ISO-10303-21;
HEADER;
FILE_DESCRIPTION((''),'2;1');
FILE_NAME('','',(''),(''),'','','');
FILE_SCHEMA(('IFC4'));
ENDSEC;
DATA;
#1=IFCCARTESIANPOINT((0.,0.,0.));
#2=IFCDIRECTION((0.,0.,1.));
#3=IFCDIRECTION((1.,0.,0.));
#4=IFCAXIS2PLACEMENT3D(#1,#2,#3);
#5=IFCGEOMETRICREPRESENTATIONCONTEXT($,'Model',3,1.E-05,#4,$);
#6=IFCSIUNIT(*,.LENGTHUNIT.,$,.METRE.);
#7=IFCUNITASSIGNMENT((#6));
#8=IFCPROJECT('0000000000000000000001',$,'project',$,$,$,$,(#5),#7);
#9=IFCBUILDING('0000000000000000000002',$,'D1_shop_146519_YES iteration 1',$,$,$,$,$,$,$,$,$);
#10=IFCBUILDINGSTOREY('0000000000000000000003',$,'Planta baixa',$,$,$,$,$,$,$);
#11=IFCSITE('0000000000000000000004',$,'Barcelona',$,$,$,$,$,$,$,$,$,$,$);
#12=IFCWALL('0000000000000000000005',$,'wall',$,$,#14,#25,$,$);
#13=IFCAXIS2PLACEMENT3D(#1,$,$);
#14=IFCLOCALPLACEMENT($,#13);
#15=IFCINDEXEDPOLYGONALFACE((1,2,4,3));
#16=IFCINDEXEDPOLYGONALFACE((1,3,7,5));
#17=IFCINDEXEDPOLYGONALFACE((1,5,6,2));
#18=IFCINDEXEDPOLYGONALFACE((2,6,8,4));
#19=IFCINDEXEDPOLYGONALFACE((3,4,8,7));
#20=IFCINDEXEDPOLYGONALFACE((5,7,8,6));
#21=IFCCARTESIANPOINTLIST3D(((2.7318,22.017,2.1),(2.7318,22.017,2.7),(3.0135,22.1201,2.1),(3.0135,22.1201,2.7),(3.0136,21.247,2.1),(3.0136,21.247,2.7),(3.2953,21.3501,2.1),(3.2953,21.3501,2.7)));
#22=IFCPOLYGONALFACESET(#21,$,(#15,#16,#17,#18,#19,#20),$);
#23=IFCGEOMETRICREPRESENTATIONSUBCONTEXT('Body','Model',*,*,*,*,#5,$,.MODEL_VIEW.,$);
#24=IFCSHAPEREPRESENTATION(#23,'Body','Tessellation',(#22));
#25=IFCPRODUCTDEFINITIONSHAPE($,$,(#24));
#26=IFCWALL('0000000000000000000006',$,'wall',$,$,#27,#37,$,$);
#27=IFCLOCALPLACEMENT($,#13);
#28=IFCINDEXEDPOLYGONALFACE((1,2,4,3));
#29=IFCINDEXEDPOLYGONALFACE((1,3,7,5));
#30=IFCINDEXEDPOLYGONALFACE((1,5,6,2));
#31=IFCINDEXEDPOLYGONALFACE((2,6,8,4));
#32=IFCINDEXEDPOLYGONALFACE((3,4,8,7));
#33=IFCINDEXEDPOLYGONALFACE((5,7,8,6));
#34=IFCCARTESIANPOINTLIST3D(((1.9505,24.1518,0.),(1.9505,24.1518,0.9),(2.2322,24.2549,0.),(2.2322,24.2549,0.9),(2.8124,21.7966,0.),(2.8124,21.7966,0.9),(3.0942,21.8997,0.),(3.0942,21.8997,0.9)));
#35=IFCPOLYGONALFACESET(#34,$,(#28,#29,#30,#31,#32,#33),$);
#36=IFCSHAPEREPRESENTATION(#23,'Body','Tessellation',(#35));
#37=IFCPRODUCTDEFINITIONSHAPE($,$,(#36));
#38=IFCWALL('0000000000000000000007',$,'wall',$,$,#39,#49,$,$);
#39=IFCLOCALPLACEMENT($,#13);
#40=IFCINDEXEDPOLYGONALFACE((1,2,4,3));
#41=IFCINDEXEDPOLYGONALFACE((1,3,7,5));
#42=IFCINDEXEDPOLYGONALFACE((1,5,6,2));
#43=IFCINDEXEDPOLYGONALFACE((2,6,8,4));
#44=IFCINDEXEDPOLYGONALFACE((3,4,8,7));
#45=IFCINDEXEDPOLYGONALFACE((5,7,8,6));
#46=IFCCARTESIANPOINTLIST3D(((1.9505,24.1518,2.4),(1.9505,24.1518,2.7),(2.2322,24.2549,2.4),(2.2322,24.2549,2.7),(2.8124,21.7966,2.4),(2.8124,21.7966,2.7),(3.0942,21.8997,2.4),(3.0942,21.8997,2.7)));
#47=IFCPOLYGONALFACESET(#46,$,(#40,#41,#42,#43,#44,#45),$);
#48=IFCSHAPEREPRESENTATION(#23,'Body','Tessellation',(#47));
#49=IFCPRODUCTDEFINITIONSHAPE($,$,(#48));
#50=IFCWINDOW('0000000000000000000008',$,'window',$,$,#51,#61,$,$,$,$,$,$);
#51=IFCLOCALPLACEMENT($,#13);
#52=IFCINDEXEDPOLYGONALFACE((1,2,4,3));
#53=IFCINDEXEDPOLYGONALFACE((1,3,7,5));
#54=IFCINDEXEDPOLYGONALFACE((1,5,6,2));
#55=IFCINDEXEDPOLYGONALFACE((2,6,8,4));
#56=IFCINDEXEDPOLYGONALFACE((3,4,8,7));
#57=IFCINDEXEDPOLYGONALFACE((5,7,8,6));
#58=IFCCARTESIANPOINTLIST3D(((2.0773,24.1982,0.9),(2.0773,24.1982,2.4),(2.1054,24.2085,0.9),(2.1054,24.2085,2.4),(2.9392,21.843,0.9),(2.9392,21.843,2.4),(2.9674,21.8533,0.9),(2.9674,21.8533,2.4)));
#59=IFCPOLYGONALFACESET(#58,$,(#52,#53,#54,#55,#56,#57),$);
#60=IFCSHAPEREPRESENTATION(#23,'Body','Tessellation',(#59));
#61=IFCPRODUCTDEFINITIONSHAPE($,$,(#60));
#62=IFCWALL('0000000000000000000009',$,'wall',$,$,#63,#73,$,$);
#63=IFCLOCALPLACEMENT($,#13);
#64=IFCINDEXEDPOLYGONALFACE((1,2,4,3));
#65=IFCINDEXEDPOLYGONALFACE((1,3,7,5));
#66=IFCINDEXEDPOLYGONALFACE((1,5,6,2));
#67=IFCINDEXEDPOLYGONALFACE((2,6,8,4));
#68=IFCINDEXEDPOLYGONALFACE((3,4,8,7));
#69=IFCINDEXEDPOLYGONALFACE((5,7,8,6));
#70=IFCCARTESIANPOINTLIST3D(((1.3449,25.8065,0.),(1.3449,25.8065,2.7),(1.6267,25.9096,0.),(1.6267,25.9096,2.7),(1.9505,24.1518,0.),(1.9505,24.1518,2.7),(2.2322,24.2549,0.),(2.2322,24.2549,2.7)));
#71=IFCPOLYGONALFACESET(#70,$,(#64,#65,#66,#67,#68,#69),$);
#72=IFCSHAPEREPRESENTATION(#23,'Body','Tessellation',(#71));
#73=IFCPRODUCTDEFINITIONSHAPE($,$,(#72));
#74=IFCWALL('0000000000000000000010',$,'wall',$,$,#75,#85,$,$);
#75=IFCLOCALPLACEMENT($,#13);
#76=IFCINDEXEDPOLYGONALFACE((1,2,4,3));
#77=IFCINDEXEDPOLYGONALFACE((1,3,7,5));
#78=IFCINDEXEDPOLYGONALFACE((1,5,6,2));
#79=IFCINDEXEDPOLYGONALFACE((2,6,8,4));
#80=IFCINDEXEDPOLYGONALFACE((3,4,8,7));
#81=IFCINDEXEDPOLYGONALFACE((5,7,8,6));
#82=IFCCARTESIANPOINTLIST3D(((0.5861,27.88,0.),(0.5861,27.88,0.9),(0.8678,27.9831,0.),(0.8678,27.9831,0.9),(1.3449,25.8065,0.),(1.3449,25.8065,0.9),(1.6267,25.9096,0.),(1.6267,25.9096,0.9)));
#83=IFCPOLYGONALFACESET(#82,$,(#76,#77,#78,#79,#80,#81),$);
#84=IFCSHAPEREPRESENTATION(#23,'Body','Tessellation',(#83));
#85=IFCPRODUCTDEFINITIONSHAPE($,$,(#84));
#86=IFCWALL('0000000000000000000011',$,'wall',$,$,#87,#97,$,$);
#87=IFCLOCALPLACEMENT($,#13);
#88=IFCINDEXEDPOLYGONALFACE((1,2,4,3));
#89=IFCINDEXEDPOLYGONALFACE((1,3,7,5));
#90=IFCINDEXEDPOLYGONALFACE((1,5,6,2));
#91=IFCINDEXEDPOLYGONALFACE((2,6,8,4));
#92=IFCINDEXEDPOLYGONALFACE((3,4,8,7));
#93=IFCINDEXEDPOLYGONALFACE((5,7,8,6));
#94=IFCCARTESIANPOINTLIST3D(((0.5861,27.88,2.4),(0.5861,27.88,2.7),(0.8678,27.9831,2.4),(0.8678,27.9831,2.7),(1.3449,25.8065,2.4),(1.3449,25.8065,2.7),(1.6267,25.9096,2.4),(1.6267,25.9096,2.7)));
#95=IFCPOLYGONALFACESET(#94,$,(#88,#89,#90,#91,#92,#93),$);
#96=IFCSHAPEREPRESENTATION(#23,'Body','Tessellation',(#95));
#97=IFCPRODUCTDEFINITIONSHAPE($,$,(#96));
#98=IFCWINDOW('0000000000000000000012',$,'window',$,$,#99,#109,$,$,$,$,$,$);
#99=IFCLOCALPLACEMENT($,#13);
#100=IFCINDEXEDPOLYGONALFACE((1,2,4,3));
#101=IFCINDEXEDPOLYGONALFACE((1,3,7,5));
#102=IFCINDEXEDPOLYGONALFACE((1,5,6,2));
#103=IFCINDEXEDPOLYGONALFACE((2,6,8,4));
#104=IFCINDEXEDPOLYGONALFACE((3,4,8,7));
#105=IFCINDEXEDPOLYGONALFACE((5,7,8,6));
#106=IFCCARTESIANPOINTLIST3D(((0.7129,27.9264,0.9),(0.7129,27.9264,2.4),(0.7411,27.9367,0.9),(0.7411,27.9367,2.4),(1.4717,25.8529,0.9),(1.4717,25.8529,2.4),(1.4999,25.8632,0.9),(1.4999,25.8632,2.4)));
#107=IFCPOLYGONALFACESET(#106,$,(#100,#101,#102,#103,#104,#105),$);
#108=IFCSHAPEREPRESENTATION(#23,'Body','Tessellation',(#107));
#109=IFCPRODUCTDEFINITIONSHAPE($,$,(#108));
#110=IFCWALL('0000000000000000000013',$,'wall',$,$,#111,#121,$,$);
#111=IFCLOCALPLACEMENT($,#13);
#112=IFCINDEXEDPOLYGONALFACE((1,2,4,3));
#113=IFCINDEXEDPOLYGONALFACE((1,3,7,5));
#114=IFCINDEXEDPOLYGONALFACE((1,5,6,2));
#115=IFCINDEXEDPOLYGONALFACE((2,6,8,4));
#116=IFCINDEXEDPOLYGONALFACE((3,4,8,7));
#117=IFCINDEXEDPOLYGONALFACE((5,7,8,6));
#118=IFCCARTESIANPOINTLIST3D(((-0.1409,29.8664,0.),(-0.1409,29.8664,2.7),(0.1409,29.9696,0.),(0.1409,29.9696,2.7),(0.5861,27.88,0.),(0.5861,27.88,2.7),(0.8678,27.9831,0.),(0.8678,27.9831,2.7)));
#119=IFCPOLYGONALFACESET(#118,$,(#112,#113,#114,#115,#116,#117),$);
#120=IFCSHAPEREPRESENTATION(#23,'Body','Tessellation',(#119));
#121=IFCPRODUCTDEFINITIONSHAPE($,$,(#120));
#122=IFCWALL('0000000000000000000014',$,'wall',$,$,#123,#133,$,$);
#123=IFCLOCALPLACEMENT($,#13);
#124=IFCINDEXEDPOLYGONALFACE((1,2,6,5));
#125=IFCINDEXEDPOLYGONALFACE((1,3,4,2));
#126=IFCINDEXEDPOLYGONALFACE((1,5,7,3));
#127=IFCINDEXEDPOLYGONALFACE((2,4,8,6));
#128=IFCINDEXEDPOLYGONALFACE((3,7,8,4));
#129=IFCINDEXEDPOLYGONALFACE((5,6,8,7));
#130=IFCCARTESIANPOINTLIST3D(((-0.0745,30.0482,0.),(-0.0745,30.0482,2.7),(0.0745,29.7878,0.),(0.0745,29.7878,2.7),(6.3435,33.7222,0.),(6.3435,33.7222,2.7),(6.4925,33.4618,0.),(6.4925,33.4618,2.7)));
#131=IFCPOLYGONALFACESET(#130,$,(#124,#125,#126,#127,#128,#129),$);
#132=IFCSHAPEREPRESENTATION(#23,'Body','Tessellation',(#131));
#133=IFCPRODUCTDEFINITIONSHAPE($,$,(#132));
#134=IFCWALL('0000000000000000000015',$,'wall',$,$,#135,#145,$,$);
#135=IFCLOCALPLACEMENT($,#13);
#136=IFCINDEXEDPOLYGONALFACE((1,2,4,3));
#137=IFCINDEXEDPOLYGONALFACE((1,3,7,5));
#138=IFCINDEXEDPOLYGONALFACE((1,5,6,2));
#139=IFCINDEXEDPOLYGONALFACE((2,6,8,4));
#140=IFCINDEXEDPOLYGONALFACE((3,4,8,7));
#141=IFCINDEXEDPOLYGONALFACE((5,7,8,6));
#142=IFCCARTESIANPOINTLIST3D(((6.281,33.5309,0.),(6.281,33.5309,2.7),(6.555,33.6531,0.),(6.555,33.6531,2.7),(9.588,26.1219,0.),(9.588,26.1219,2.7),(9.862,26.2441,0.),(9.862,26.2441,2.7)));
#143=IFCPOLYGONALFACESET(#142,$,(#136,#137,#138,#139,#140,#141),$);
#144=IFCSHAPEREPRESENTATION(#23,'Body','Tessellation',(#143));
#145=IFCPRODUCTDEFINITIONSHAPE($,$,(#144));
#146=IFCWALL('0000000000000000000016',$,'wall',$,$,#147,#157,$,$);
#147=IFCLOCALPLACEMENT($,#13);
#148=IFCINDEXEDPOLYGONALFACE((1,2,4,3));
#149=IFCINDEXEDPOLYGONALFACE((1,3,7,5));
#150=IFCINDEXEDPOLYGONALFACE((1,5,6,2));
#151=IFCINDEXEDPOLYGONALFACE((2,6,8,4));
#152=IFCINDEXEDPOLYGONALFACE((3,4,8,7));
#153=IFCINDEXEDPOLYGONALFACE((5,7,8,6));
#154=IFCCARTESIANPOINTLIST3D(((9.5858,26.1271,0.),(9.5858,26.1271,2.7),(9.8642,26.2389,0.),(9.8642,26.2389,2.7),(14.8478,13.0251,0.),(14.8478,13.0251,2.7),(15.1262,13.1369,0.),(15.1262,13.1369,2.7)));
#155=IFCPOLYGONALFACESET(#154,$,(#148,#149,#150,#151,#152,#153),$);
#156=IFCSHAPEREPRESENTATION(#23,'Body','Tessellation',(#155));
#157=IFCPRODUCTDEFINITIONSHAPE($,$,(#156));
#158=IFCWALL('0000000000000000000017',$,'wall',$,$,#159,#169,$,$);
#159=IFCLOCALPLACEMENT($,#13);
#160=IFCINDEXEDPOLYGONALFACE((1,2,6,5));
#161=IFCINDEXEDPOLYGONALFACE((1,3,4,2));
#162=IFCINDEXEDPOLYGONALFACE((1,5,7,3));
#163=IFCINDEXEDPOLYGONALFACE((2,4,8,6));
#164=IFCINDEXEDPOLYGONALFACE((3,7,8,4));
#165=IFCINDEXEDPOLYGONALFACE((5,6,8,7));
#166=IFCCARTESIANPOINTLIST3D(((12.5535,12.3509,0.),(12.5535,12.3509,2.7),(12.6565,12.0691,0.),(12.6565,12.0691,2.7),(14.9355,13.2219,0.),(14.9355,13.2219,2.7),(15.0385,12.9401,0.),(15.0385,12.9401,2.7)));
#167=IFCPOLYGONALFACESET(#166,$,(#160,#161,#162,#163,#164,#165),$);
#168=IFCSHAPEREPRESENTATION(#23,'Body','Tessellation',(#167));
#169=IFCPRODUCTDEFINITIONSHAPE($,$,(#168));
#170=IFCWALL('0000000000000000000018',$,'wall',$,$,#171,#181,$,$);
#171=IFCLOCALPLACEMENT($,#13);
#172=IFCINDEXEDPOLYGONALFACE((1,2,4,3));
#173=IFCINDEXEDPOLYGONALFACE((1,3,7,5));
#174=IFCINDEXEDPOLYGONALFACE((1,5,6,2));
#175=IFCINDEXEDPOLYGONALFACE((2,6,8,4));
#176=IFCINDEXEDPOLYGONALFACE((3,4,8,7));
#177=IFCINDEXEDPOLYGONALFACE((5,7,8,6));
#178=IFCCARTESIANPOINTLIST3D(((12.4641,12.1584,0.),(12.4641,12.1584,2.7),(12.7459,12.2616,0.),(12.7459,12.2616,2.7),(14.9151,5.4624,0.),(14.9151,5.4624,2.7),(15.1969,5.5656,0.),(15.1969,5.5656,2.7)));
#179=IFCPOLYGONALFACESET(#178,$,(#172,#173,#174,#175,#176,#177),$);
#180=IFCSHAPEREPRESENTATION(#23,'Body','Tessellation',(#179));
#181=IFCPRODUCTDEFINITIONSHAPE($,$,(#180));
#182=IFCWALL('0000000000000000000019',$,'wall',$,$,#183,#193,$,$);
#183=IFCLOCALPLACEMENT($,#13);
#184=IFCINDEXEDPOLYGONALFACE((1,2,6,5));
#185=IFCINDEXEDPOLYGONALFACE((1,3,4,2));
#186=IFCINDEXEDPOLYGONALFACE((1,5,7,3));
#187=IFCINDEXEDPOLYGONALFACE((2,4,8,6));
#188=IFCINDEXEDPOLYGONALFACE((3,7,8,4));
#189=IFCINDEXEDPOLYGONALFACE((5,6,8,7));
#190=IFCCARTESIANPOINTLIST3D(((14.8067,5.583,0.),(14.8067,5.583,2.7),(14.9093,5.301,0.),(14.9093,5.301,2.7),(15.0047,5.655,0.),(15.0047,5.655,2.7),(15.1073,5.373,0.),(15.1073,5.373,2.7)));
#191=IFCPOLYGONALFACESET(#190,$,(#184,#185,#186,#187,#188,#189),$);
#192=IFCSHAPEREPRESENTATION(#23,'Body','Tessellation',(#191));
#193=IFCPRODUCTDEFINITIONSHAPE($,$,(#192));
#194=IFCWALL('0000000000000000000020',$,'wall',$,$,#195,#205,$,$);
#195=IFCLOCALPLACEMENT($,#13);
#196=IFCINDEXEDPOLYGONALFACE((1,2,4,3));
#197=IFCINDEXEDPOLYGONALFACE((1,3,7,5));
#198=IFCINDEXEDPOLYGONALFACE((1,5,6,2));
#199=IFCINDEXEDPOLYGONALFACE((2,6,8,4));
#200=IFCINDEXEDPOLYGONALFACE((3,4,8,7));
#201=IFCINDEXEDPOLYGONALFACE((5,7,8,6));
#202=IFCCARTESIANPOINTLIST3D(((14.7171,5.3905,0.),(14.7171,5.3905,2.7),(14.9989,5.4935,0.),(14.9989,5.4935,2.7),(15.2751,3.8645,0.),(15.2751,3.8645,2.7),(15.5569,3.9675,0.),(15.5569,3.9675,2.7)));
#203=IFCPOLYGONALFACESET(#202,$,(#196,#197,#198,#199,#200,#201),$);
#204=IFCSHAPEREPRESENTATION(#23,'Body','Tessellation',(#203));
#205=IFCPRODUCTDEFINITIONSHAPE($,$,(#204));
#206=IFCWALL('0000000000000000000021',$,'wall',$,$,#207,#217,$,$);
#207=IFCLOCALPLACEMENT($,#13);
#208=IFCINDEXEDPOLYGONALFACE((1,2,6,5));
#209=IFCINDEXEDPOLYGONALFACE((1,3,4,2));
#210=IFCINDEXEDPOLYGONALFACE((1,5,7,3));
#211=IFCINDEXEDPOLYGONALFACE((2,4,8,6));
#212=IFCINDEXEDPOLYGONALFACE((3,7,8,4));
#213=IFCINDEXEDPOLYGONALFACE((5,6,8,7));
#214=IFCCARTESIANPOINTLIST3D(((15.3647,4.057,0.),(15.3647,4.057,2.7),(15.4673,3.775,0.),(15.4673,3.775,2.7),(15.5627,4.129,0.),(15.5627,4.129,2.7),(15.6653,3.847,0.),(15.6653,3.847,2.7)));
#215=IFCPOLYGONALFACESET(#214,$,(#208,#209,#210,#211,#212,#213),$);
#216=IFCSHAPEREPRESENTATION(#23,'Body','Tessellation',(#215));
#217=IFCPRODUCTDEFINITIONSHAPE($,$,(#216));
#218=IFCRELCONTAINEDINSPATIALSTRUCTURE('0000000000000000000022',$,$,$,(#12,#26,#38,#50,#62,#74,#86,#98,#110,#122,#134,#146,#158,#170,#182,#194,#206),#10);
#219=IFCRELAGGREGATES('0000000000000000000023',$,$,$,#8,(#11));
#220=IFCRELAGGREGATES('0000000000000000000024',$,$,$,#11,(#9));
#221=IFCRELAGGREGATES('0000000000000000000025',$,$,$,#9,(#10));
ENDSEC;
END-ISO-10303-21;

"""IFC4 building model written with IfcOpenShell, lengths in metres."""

from ifc_helpers import new_model, si_unit, frame, origin, origin_with_axes, place, context, subcontext, project, spatial, polyline, outline, extrude, element, save


model = new_model("IFC4")

# Units and contexts
model_context = context("Model", 3, precision=1e-05, world=origin_with_axes())
body_context = subcontext(model_context, "Body", "Model", "MODEL_VIEW")
ifc_project = project(units=[si_unit("LENGTHUNIT", "METRE")], contexts=[model_context])

# Site, building, storey
site = spatial("IfcSite", under=ifc_project, Name="Barcelona")
building = spatial("IfcBuilding", under=site, Name="D1_shop_146519_YES iteration 1")
storey = spatial("IfcBuildingStorey", under=building, Name="Planta baixa")

# Walls
wall_1_placement = place(None, origin_with_axes())
element("IfcWall", 1, at=wall_1_placement, inside=storey, Name="wall", context=body_context, shape_type="SweptSolid", body=[
    extrude(outline(polyline([(3.0136, 21.247), (2.7318, 22.017), (3.0135, 22.1201), (3.2953, 21.3501), (3.0136, 21.247)])), frame((0.0, 0.0, 2.1)), (0.0, 0.0, 1.0), 0.6),
])
wall_2_placement = place(None, origin_with_axes())
element("IfcWall", 2, at=wall_2_placement, inside=storey, Name="wall", context=body_context, shape_type="SweptSolid", body=[
    extrude(outline(polyline([(2.8124, 21.7966), (1.9505, 24.1518), (2.2322, 24.2549), (3.0942, 21.8997), (2.8124, 21.7966)])), origin(), (0.0, 0.0, 1.0), 0.9),
])
wall_3_placement = place(None, origin_with_axes())
element("IfcWall", 3, at=wall_3_placement, inside=storey, Name="wall", context=body_context, shape_type="SweptSolid", body=[
    extrude(outline(polyline([(2.8124, 21.7966), (1.9505, 24.1518), (2.2322, 24.2549), (3.0942, 21.8997), (2.8124, 21.7966)])), frame((0.0, 0.0, 2.4)), (0.0, 0.0, 1.0), 0.3),
])

# Window
window_1_placement = place(None, origin_with_axes())
element("IfcWindow", 4, at=window_1_placement, inside=storey, Name="window", context=body_context, shape_type="SweptSolid", body=[
    extrude(outline(polyline([(2.9392, 21.843), (2.0773, 24.1982), (2.1054, 24.2085), (2.9674, 21.8533), (2.9392, 21.843)])), frame((0.0, 0.0, 0.9)), (0.0, 0.0, 1.0), 1.5),
])

# Walls
wall_4_placement = place(None, origin_with_axes())
element("IfcWall", 5, at=wall_4_placement, inside=storey, Name="wall", context=body_context, shape_type="SweptSolid", body=[
    extrude(outline(polyline([(1.9505, 24.1518), (1.3449, 25.8065), (1.6267, 25.9096), (2.2322, 24.2549), (1.9505, 24.1518)])), origin(), (0.0, 0.0, 1.0), 2.7),
])
wall_5_placement = place(None, origin_with_axes())
element("IfcWall", 6, at=wall_5_placement, inside=storey, Name="wall", context=body_context, shape_type="SweptSolid", body=[
    extrude(outline(polyline([(1.3449, 25.8065), (0.5861, 27.88), (0.8678, 27.9831), (1.6267, 25.9096), (1.3449, 25.8065)])), origin(), (0.0, 0.0, 1.0), 0.9),
])
wall_6_placement = place(None, origin_with_axes())
element("IfcWall", 7, at=wall_6_placement, inside=storey, Name="wall", context=body_context, shape_type="SweptSolid", body=[
    extrude(outline(polyline([(1.3449, 25.8065), (0.5861, 27.88), (0.8678, 27.9831), (1.6267, 25.9096), (1.3449, 25.8065)])), frame((0.0, 0.0, 2.4)), (0.0, 0.0, 1.0), 0.3),
])

# Window
window_2_placement = place(None, origin_with_axes())
element("IfcWindow", 8, at=window_2_placement, inside=storey, Name="window", context=body_context, shape_type="SweptSolid", body=[
    extrude(outline(polyline([(1.4717, 25.8529), (0.7129, 27.9264), (0.7411, 27.9367), (1.4999, 25.8632), (1.4717, 25.8529)])), frame((0.0, 0.0, 0.9)), (0.0, 0.0, 1.0), 1.5),
])

# Walls
wall_7_placement = place(None, origin_with_axes())
element("IfcWall", 9, at=wall_7_placement, inside=storey, Name="wall", context=body_context, shape_type="SweptSolid", body=[
    extrude(outline(polyline([(0.5861, 27.88), (-0.1409, 29.8664), (0.1409, 29.9696), (0.8678, 27.9831), (0.5861, 27.88)])), origin(), (0.0, 0.0, 1.0), 2.7),
])
wall_8_placement = place(None, origin_with_axes())
element("IfcWall", 10, at=wall_8_placement, inside=storey, Name="wall", context=body_context, shape_type="SweptSolid", body=[
    extrude(outline(polyline([(-0.0745, 30.0482), (6.3435, 33.7222), (6.4925, 33.4618), (0.0745, 29.7878), (-0.0745, 30.0482)])), origin(), (0.0, 0.0, 1.0), 2.7),
])
wall_9_placement = place(None, origin_with_axes())
element("IfcWall", 11, at=wall_9_placement, inside=storey, Name="wall", context=body_context, shape_type="SweptSolid", body=[
    extrude(outline(polyline([(6.555, 33.6531), (9.862, 26.2441), (9.588, 26.1219), (6.281, 33.5309), (6.555, 33.6531)])), origin(), (0.0, 0.0, 1.0), 2.7),
])
wall_10_placement = place(None, origin_with_axes())
element("IfcWall", 12, at=wall_10_placement, inside=storey, Name="wall", context=body_context, shape_type="SweptSolid", body=[
    extrude(outline(polyline([(9.8642, 26.2389), (15.1262, 13.1369), (14.8478, 13.0251), (9.5858, 26.1271), (9.8642, 26.2389)])), origin(), (0.0, 0.0, 1.0), 2.7),
])
wall_11_placement = place(None, origin_with_axes())
element("IfcWall", 13, at=wall_11_placement, inside=storey, Name="wall", context=body_context, shape_type="SweptSolid", body=[
    extrude(outline(polyline([(15.0385, 12.9401), (12.6565, 12.0691), (12.5535, 12.3509), (14.9355, 13.2219), (15.0385, 12.9401)])), origin(), (0.0, 0.0, 1.0), 2.7),
])
wall_12_placement = place(None, origin_with_axes())
element("IfcWall", 14, at=wall_12_placement, inside=storey, Name="wall", context=body_context, shape_type="SweptSolid", body=[
    extrude(outline(polyline([(12.7459, 12.2616), (15.1969, 5.5656), (14.9151, 5.4624), (12.4641, 12.1584), (12.7459, 12.2616)])), origin(), (0.0, 0.0, 1.0), 2.7),
])
wall_13_placement = place(None, origin_with_axes())
element("IfcWall", 15, at=wall_13_placement, inside=storey, Name="wall", context=body_context, shape_type="SweptSolid", body=[
    extrude(outline(polyline([(15.1073, 5.373), (14.9093, 5.301), (14.8067, 5.583), (15.0047, 5.655), (15.1073, 5.373)])), origin(), (0.0, 0.0, 1.0), 2.7),
])
wall_14_placement = place(None, origin_with_axes())
element("IfcWall", 16, at=wall_14_placement, inside=storey, Name="wall", context=body_context, shape_type="SweptSolid", body=[
    extrude(outline(polyline([(14.9989, 5.4935), (15.5569, 3.9675), (15.2751, 3.8645), (14.7171, 5.3905), (14.9989, 5.4935)])), origin(), (0.0, 0.0, 1.0), 2.7),
])
wall_15_placement = place(None, origin_with_axes())
element("IfcWall", 17, at=wall_15_placement, inside=storey, Name="wall", context=body_context, shape_type="SweptSolid", body=[
    extrude(outline(polyline([(15.3647, 4.057), (15.5627, 4.129), (15.6653, 3.847), (15.4673, 3.775), (15.3647, 4.057)])), origin(), (0.0, 0.0, 1.0), 2.7),
])

save(model, "model.ifc")
